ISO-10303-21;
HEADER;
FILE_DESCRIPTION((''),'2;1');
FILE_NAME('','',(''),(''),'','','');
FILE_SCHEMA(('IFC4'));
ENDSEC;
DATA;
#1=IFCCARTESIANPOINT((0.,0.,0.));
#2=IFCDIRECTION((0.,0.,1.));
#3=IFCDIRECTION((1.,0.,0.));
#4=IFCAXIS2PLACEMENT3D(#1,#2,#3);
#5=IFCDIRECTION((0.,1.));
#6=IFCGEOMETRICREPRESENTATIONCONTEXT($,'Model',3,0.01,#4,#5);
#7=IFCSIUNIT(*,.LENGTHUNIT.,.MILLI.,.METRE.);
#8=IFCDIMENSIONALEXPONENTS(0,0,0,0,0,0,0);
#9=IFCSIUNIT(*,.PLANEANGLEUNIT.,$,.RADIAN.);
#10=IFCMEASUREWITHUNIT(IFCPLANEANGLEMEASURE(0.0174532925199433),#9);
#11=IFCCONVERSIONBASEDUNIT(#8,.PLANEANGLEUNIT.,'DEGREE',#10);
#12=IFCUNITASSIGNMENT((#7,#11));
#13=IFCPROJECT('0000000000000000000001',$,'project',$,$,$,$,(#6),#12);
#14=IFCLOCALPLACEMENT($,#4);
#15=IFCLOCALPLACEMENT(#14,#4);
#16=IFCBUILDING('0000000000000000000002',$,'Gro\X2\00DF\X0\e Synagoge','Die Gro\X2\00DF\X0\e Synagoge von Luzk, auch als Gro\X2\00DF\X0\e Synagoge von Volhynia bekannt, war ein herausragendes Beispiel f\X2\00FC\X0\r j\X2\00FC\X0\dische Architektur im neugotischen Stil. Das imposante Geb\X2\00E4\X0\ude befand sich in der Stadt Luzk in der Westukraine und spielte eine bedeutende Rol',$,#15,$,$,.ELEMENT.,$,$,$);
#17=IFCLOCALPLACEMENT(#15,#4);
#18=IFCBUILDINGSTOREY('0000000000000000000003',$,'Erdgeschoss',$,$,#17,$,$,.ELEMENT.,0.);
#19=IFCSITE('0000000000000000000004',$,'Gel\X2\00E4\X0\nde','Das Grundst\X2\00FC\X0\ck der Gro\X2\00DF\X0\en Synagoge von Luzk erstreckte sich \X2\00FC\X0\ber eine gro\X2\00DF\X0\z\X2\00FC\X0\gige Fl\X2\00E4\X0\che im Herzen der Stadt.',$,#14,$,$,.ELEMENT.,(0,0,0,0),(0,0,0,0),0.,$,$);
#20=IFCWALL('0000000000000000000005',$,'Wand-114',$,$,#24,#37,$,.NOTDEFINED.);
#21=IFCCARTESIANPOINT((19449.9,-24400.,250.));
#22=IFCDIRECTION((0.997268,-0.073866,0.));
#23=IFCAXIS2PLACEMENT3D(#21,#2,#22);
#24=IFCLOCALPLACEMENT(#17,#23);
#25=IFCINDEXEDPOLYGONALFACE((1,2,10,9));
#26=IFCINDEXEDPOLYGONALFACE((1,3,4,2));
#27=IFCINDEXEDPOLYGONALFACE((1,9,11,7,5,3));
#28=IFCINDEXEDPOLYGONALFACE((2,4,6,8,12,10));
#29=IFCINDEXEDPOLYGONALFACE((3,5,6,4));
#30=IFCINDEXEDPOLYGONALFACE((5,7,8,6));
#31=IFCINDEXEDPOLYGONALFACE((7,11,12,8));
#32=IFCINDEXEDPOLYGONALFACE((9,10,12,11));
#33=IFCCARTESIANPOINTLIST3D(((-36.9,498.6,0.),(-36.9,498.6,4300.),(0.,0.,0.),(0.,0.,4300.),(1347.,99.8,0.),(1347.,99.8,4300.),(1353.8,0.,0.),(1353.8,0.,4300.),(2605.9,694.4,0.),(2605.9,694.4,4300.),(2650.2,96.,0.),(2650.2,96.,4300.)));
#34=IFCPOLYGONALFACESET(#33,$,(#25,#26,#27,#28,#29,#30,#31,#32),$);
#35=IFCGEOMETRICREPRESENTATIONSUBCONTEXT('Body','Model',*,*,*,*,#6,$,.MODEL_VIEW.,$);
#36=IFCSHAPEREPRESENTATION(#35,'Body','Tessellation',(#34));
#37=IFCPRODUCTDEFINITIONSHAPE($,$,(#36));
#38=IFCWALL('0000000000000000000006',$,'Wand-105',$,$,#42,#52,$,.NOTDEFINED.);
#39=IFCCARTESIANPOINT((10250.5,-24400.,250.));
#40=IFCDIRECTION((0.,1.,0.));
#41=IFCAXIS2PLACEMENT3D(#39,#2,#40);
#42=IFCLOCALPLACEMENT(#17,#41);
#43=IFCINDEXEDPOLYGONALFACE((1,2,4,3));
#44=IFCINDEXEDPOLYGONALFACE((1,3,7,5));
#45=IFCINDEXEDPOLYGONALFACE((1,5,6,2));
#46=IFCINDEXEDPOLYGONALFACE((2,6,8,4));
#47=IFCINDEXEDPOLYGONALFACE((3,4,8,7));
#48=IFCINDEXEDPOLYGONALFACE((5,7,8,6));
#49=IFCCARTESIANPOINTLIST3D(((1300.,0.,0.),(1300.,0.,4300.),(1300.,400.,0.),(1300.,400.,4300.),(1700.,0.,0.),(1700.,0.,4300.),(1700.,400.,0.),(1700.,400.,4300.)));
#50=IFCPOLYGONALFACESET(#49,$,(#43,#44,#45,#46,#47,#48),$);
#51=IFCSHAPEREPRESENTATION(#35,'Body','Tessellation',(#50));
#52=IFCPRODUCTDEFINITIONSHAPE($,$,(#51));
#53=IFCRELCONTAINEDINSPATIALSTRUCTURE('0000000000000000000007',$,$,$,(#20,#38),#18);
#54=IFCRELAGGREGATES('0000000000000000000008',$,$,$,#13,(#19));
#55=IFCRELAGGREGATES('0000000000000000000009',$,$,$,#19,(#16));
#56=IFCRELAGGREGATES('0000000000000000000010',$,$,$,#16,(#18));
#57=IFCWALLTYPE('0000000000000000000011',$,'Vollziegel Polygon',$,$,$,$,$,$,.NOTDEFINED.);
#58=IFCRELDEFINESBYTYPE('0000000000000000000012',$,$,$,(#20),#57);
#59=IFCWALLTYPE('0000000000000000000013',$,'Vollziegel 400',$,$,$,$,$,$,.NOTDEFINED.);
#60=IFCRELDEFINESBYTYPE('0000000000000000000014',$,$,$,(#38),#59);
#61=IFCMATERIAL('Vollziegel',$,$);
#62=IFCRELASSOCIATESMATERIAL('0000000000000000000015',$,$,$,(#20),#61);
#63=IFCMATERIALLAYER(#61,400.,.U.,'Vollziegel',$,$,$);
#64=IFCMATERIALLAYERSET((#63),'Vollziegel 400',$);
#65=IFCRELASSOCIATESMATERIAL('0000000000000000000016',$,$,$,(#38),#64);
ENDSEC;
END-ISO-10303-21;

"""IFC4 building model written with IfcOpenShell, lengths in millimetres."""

from ifc_helpers import new_model, entity, si_unit, converted_unit, direction, frame, origin_with_axes, place, context, subcontext, project, spatial, line, indexed_curve, outline, extrude, material, layer, layer_set, layer_usage, type_object, element, save


model = new_model("IFC4")

# Units and contexts
model_context = context("Model", 3, precision=0.01, world=origin_with_axes(), true_north=direction((0.0, 1.0)))
body_context = subcontext(model_context, "Body", "Model", "MODEL_VIEW")
ifc_project = project(units=[si_unit("LENGTHUNIT", "METRE", prefix="MILLI"), converted_unit("PLANEANGLEUNIT", "DEGREE", entity("IfcPlaneAngleMeasure", 0.0174532925199433), si_unit("PLANEANGLEUNIT", "RADIAN"), dimensions=[0, 0, 0, 0, 0, 0, 0])], contexts=[model_context])

# Site, building, storey
site_placement = place(None, origin_with_axes())
site = spatial("IfcSite", under=ifc_project, at=site_placement, Name="Gelände", Description="Das Grundstück der Großen Synagoge von Luzk erstreckte sich über eine großzügige Fläche im Herzen der Stadt.", CompositionType="ELEMENT", RefLatitude=(0, 0, 0, 0), RefLongitude=(0, 0, 0, 0), RefElevation=0.0)
building_placement = place(site_placement, origin_with_axes())
building = spatial("IfcBuilding", under=site, at=building_placement, Name="Große Synagoge", Description="Die Große Synagoge von Luzk, auch als Große Synagoge von Volhynia bekannt, war ein herausragendes Beispiel für jüdische Architektur im neugotischen Stil. Das imposante Gebäude befand sich in der Stadt Luzk in der Westukraine und spielte eine bedeutende Rol", CompositionType="ELEMENT")
storey_placement = place(building_placement, origin_with_axes())
storey = spatial("IfcBuildingStorey", under=building, at=storey_placement, Name="Erdgeschoss", CompositionType="ELEMENT", Elevation=0.0)

# Shared definitions
ifc_material_1 = material(Name="Vollziegel")

# Walls
wall_type_1 = type_object("IfcWallType", Name="Vollziegel Polygon", PredefinedType="NOTDEFINED")
wall_1_placement = place(storey_placement, frame((19449.9, -24400.0, 250.0), z_axis=(0.0, 0.0, 1.0), x_axis=(0.997268, -0.073866, 0.0)))
element("IfcWall", 1, at=wall_1_placement, inside=storey, type_object=wall_type_1, material=ifc_material_1, Name="Wand-114", PredefinedType="NOTDEFINED", context=body_context, shape_type="SweptSolid", body=[
    extrude(outline(indexed_curve([(0.0, 0.0), (1347.0, 99.8), (1353.8, 0.0), (2650.2, 96.0), (2605.9, 694.4), (-36.9, 498.6)], segments=[line(1, 2, 3, 4, 5, 6, 1)])), origin_with_axes(), (0.0, 0.0, 1.0), 4300.0),
])
ifc_layer_1 = layer(ifc_material_1, 400.0, ventilated="UNKNOWN", Name="Vollziegel")
ifc_layer_set_1 = layer_set([ifc_layer_1], Name="Vollziegel 400")
ifc_layer_usage_1 = layer_usage(ifc_layer_set_1, "AXIS2", "POSITIVE", 0.0)
wall_type_2 = type_object("IfcWallType", Name="Vollziegel 400", PredefinedType="NOTDEFINED")
wall_2_placement = place(storey_placement, frame((10250.5, -24400.0, 250.0), z_axis=(0.0, 0.0, 1.0), x_axis=(0.0, 1.0, 0.0)))
element("IfcWall", 2, at=wall_2_placement, inside=storey, type_object=wall_type_2, material=ifc_layer_usage_1, Name="Wand-105", PredefinedType="NOTDEFINED", context=body_context, shape_type="SweptSolid", body=[
    extrude(outline(indexed_curve([(1300.0, 0.0), (1700.0, 0.0), (1700.0, 400.0), (1300.0, 400.0)], segments=[line(1, 2, 3, 4, 1)])), origin_with_axes(), (0.0, 0.0, 1.0), 4300.0),
])

save(model, "model.ifc")
